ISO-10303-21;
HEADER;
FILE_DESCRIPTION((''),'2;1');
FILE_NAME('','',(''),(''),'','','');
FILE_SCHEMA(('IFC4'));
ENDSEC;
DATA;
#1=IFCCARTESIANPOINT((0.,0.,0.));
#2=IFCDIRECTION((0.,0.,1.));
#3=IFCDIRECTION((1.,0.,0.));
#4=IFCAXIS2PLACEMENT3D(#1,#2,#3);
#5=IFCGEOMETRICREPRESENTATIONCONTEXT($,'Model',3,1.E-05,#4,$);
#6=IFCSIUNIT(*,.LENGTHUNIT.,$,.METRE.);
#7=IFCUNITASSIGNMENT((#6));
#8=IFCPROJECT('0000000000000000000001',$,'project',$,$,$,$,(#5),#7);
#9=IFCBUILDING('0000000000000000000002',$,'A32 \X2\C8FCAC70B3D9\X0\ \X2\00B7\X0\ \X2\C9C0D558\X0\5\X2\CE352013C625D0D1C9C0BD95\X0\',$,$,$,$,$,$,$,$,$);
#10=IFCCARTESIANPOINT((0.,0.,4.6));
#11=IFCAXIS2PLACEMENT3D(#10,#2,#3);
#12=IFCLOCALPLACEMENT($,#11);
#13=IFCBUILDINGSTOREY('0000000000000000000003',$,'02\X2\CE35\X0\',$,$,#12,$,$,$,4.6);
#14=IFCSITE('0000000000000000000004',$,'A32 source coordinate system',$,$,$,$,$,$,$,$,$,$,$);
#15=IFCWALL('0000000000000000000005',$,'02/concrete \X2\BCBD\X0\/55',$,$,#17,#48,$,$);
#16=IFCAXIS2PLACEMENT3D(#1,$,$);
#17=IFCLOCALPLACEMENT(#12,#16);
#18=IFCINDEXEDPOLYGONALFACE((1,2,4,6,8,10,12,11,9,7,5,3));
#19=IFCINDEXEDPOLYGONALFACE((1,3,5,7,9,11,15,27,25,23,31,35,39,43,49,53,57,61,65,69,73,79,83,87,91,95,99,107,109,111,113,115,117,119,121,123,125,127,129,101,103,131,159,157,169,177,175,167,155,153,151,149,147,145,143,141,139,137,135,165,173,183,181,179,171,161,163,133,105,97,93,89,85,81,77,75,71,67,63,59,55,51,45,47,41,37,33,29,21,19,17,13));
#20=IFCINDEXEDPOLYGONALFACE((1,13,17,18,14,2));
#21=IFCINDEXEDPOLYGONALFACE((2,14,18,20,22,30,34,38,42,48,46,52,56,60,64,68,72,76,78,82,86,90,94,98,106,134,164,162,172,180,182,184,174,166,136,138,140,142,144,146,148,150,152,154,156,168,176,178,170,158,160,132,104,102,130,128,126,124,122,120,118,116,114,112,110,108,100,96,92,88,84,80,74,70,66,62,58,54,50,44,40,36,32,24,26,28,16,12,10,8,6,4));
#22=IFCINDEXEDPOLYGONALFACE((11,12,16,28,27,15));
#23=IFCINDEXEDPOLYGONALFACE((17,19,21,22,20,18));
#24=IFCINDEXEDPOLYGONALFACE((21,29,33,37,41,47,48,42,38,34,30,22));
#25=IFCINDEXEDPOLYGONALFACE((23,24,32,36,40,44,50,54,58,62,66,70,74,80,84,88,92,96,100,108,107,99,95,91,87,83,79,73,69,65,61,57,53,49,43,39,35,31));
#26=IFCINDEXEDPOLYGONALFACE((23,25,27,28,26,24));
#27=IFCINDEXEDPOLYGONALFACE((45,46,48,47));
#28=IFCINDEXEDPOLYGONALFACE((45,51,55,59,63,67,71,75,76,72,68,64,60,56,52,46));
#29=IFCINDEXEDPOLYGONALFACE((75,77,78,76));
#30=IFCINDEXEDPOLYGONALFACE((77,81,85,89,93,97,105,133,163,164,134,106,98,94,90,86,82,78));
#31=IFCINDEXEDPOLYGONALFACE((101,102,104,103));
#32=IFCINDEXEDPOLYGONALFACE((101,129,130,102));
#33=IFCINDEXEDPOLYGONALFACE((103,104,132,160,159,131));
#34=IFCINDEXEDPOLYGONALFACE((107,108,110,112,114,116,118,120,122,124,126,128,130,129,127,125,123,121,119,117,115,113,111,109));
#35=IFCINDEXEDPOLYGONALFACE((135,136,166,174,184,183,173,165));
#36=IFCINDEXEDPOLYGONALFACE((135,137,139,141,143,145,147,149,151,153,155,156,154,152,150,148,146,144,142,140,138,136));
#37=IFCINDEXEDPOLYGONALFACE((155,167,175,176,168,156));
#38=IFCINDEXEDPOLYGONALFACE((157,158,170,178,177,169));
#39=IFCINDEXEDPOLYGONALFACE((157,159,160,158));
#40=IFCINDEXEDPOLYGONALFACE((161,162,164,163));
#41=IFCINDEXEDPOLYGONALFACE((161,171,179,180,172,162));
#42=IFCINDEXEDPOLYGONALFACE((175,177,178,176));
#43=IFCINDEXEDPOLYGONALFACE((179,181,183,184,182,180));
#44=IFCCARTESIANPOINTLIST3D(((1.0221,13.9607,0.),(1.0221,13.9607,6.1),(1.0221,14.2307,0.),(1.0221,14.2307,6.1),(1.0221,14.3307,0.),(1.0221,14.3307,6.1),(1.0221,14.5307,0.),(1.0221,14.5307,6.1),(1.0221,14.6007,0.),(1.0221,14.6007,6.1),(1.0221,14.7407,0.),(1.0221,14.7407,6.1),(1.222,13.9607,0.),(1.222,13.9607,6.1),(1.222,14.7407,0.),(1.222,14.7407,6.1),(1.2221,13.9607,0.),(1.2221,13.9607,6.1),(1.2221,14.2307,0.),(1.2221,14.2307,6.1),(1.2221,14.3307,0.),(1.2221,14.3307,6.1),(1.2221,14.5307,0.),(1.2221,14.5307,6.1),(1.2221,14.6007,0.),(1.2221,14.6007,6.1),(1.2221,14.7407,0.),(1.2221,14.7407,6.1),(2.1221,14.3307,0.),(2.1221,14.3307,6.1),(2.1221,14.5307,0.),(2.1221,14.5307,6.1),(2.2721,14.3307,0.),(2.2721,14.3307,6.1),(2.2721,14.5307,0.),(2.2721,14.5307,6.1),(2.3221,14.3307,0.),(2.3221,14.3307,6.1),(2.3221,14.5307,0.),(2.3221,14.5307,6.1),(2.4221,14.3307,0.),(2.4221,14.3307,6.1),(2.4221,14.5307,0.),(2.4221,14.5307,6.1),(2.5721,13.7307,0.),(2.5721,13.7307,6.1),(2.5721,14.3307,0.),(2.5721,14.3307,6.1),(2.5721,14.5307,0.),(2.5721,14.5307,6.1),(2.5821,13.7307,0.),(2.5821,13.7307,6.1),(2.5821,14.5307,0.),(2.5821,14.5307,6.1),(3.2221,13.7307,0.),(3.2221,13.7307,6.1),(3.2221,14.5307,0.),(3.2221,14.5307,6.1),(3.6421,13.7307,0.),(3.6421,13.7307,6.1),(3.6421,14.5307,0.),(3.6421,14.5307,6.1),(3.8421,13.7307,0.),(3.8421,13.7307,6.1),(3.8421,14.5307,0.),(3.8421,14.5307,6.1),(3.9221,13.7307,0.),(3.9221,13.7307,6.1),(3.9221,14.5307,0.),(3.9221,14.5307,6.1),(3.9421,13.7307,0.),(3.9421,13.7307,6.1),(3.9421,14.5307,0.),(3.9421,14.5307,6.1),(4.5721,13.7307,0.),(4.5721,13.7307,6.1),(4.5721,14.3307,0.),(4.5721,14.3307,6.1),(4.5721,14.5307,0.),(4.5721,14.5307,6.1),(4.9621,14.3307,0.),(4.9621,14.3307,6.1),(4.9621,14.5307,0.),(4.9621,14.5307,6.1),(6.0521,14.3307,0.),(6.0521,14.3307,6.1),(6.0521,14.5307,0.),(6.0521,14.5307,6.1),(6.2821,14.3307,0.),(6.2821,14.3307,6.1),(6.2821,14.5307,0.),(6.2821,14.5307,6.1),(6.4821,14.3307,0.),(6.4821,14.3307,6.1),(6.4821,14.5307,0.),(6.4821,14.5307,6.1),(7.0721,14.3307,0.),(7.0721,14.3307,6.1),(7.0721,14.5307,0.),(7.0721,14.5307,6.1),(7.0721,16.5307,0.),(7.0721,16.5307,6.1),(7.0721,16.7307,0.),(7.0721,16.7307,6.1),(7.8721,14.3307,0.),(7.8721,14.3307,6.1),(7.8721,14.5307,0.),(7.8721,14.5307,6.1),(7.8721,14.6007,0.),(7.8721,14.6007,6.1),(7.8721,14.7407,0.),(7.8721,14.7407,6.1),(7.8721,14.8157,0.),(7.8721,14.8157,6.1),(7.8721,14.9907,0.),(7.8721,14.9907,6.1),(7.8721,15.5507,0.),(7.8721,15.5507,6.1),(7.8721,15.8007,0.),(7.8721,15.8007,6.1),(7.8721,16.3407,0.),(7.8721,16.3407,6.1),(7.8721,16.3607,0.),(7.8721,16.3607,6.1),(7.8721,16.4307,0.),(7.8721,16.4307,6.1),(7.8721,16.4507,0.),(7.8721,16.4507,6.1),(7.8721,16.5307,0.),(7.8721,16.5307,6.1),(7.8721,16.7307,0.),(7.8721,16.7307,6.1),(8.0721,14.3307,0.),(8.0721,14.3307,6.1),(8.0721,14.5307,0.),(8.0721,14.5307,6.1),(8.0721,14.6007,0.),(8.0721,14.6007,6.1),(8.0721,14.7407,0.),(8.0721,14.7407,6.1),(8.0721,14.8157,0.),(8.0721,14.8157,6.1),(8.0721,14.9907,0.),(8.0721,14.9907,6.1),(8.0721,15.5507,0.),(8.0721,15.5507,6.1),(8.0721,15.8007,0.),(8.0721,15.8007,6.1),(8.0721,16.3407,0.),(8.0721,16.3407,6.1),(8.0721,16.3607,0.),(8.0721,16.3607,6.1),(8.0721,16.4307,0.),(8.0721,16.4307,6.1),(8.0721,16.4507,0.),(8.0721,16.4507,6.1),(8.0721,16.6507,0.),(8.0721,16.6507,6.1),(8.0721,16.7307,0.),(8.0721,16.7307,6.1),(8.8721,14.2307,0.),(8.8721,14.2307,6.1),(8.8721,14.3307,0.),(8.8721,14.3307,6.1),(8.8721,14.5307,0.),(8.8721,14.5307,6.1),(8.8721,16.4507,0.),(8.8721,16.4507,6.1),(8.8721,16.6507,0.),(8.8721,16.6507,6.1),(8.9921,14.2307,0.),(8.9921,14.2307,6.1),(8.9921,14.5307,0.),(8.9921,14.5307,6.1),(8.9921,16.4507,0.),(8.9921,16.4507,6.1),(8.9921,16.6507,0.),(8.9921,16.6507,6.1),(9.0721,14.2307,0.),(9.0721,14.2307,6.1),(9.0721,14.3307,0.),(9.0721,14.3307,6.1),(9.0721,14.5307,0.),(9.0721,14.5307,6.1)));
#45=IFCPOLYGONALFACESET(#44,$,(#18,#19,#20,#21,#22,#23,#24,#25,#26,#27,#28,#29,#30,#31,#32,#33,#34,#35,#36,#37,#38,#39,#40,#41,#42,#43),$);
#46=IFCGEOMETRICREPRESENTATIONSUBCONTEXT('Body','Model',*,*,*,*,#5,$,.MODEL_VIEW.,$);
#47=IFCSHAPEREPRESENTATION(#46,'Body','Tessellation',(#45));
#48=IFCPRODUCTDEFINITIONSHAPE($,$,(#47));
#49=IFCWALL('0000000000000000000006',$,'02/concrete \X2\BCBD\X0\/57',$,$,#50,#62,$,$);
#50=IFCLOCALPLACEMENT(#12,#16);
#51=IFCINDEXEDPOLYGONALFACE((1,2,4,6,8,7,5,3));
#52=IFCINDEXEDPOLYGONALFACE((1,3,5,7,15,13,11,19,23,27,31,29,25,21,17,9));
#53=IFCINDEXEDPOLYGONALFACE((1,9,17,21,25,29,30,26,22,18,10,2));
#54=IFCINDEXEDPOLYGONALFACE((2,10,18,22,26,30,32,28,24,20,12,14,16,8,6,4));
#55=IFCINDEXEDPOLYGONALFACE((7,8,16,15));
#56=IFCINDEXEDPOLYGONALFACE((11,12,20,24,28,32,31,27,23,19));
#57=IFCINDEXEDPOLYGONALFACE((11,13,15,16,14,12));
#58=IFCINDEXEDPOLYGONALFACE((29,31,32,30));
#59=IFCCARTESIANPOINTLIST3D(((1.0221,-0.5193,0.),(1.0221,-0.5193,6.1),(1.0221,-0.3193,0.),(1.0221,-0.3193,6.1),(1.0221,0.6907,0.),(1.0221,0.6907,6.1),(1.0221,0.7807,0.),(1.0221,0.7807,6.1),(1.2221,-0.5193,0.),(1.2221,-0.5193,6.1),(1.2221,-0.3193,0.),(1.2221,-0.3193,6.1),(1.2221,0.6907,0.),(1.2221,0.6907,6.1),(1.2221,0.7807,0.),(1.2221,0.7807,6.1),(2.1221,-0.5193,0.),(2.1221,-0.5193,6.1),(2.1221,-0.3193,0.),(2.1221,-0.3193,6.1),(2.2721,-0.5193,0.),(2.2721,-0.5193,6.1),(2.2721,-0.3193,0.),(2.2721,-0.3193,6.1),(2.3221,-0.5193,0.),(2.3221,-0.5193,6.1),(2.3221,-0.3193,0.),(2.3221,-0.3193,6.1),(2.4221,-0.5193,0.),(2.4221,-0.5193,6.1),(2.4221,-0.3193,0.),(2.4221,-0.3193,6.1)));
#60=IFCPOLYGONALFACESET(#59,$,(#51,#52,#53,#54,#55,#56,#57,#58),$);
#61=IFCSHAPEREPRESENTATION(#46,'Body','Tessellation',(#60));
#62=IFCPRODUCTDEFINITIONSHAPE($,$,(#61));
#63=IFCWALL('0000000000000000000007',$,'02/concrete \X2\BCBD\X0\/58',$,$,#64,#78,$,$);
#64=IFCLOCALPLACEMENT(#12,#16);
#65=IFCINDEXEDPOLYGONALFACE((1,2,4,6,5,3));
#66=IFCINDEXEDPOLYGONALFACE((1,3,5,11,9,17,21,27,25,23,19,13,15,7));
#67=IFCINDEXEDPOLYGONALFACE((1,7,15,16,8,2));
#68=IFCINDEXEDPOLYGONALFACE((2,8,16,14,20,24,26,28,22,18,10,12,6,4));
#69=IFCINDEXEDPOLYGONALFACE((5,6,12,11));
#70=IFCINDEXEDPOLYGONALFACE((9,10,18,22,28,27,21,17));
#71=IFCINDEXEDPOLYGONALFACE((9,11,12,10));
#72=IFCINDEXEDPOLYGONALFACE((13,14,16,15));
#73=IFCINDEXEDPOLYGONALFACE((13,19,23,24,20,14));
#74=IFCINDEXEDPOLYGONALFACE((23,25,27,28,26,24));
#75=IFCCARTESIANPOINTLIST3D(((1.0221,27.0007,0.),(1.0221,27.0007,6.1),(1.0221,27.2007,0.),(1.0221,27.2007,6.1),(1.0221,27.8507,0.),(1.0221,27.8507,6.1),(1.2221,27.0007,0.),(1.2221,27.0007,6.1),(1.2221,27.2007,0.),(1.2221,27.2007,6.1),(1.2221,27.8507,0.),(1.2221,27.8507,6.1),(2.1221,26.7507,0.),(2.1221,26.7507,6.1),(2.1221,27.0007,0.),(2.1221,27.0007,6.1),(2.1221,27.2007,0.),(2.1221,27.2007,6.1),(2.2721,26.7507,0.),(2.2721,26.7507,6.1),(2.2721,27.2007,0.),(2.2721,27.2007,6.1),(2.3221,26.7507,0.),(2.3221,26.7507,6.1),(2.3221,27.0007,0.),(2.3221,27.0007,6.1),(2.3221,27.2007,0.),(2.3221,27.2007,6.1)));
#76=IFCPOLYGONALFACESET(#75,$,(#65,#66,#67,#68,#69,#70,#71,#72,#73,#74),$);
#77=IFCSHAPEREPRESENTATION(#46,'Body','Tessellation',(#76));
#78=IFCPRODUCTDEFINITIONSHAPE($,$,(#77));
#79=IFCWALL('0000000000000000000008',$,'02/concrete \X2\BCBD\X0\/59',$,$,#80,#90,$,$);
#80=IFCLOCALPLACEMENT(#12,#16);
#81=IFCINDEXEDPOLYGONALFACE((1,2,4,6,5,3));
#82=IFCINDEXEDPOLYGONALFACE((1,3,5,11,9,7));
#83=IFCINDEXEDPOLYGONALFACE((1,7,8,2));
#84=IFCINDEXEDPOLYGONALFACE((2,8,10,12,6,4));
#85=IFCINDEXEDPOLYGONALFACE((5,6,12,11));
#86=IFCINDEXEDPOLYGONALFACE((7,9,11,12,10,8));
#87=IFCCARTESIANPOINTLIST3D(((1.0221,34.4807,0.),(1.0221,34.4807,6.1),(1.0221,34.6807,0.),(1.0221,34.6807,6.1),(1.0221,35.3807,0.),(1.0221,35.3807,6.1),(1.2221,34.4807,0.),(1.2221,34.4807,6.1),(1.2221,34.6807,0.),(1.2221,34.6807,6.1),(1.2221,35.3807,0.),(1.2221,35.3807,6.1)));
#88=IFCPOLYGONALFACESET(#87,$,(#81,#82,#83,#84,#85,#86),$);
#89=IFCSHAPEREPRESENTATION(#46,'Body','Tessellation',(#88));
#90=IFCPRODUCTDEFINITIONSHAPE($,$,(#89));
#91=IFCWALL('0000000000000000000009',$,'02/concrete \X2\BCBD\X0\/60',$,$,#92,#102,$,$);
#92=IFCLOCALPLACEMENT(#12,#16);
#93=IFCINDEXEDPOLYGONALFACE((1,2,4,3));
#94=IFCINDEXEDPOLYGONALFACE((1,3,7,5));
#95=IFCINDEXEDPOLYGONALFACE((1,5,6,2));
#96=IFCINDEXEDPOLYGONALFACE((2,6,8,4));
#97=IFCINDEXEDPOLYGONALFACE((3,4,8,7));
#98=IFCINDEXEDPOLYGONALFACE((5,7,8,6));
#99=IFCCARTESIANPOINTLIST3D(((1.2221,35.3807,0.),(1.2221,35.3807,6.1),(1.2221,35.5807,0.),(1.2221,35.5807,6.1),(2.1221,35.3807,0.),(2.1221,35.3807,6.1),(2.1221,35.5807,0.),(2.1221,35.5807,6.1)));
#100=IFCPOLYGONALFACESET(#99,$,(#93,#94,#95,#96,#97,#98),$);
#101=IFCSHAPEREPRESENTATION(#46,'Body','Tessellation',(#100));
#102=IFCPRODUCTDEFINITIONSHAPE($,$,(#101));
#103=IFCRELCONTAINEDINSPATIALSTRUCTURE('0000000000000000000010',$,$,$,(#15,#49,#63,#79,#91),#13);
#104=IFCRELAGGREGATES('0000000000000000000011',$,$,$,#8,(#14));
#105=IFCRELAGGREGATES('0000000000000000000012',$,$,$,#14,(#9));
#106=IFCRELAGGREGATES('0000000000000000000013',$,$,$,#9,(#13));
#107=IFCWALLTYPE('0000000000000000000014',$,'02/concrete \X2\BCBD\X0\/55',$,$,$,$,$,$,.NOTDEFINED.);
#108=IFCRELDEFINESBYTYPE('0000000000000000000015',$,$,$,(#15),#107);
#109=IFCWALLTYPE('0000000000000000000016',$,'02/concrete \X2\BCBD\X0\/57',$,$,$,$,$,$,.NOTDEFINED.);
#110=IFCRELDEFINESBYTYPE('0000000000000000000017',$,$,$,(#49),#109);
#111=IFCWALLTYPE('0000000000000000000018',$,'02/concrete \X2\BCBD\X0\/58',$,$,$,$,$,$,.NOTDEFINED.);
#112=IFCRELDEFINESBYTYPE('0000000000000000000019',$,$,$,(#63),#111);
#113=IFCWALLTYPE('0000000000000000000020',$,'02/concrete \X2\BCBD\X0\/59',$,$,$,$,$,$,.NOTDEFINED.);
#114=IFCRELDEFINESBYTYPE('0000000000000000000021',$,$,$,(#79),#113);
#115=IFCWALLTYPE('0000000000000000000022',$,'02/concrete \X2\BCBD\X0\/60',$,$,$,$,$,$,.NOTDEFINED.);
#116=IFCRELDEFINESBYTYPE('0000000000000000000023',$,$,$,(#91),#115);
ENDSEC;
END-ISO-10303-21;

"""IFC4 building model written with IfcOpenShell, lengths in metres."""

from ifc_helpers import new_model, si_unit, frame, origin, origin_with_axes, place, context, subcontext, project, spatial, polyline, outline, extrude, source, transform, mapped, type_object, type_shapes, element, save


model = new_model("IFC4")

# Units and contexts
model_context = context("Model", 3, precision=1e-05, world=origin_with_axes())
body_context = subcontext(model_context, "Body", "Model", "MODEL_VIEW")
ifc_project = project(units=[si_unit("LENGTHUNIT", "METRE")], contexts=[model_context])

# Site, building, storey
site = spatial("IfcSite", under=ifc_project, Name="A32 source coordinate system")
building = spatial("IfcBuilding", under=site, Name="A32 주거동 · 지하5층–옥탑지붕")
storey_placement = place(None, frame((0.0, 0.0, 4.6), z_axis=(0.0, 0.0, 1.0), x_axis=(1.0, 0.0, 0.0)))
storey = spatial("IfcBuildingStorey", under=building, at=storey_placement, Name="02층", Elevation=4.6)

# Walls
wall_type_1 = type_object("IfcWallType", Name="02/concrete 벽/55", PredefinedType="NOTDEFINED")
shared_shape_1 = source(origin(), body_context, "Body", "SweptSolid", [
    extrude(outline(polyline([(2.1221, 14.5307), (2.2721, 14.5307), (2.3221, 14.5307), (2.4221, 14.5307), (2.5721, 14.5307), (2.5821, 14.5307), (3.2221, 14.5307), (3.6421, 14.5307), (3.8421, 14.5307), (3.9221, 14.5307), (3.9421, 14.5307), (4.5721, 14.5307), (4.9621, 14.5307), (6.0521, 14.5307), (6.2821, 14.5307), (6.4821, 14.5307), (7.0721, 14.5307), (7.8721, 14.5307), (7.8721, 14.6007), (7.8721, 14.7407), (7.8721, 14.8157), (7.8721, 14.9907), (7.8721, 15.5507), (7.8721, 15.8007), (7.8721, 16.3407), (7.8721, 16.3607), (7.8721, 16.4307), (7.8721, 16.4507), (7.8721, 16.5307), (7.0721, 16.5307), (7.0721, 16.7307), (7.8721, 16.7307), (8.0721, 16.7307), (8.0721, 16.6507), (8.8721, 16.6507), (8.9921, 16.6507), (8.9921, 16.4507), (8.8721, 16.4507), (8.0721, 16.4507), (8.0721, 16.4307), (8.0721, 16.3607), (8.0721, 16.3407), (8.0721, 15.8007), (8.0721, 15.5507), (8.0721, 14.9907), (8.0721, 14.8157), (8.0721, 14.7407), (8.0721, 14.6007), (8.0721, 14.5307), (8.8721, 14.5307), (8.9921, 14.5307), (9.0721, 14.5307), (9.0721, 14.3307), (9.0721, 14.2307), (8.9921, 14.2307), (8.8721, 14.2307), (8.8721, 14.3307), (8.0721, 14.3307), (7.8721, 14.3307), (7.0721, 14.3307), (6.4821, 14.3307), (6.2821, 14.3307), (6.0521, 14.3307), (4.9621, 14.3307), (4.5721, 14.3307), (4.5721, 13.7307), (3.9421, 13.7307), (3.9221, 13.7307), (3.8421, 13.7307), (3.6421, 13.7307), (3.2221, 13.7307), (2.5821, 13.7307), (2.5721, 13.7307), (2.5721, 14.3307), (2.4221, 14.3307), (2.3221, 14.3307), (2.2721, 14.3307), (2.1221, 14.3307), (1.2221, 14.3307), (1.2221, 14.2307), (1.2221, 13.9607), (1.222, 13.9607), (1.0221, 13.9607), (1.0221, 14.2307), (1.0221, 14.3307), (1.0221, 14.5307), (1.0221, 14.6007), (1.0221, 14.7407), (1.222, 14.7407), (1.2221, 14.7407), (1.2221, 14.6007), (1.2221, 14.5307), (2.1221, 14.5307)])), origin(), (0.0, 0.0, 1.0), 6.1),
])
type_shapes(wall_type_1, [shared_shape_1])
wall_1_placement = place(storey_placement, origin_with_axes())
element("IfcWall", 1, at=wall_1_placement, inside=storey, type_object=wall_type_1, Name="02/concrete 벽/55", context=body_context, shape_type="MappedRepresentation", body=[
    mapped(shared_shape_1, transform((0.0, 0.0, 0.0), scale=1.0)),
])
wall_type_2 = type_object("IfcWallType", Name="02/concrete 벽/57", PredefinedType="NOTDEFINED")
shared_shape_2 = source(origin(), body_context, "Body", "SweptSolid", [
    extrude(outline(polyline([(2.1221, -0.3193), (2.2721, -0.3193), (2.3221, -0.3193), (2.4221, -0.3193), (2.4221, -0.5193), (2.3221, -0.5193), (2.2721, -0.5193), (2.1221, -0.5193), (1.2221, -0.5193), (1.0221, -0.5193), (1.0221, -0.3193), (1.0221, 0.6907), (1.0221, 0.7807), (1.2221, 0.7807), (1.2221, 0.6907), (1.2221, -0.3193), (2.1221, -0.3193)])), origin(), (0.0, 0.0, 1.0), 6.1),
])
type_shapes(wall_type_2, [shared_shape_2])
wall_2_placement = place(storey_placement, origin_with_axes())
element("IfcWall", 2, at=wall_2_placement, inside=storey, type_object=wall_type_2, Name="02/concrete 벽/57", context=body_context, shape_type="MappedRepresentation", body=[
    mapped(shared_shape_2, transform((0.0, 0.0, 0.0), scale=1.0)),
])
wall_type_3 = type_object("IfcWallType", Name="02/concrete 벽/58", PredefinedType="NOTDEFINED")
shared_shape_3 = source(origin(), body_context, "Body", "SweptSolid", [
    extrude(outline(polyline([(1.2221, 27.2007), (2.1221, 27.2007), (2.2721, 27.2007), (2.3221, 27.2007), (2.3221, 27.0007), (2.3221, 26.7507), (2.2721, 26.7507), (2.1221, 26.7507), (2.1221, 27.0007), (1.2221, 27.0007), (1.0221, 27.0007), (1.0221, 27.2007), (1.0221, 27.8507), (1.2221, 27.8507), (1.2221, 27.2007)])), origin(), (0.0, 0.0, 1.0), 6.1),
])
type_shapes(wall_type_3, [shared_shape_3])
wall_3_placement = place(storey_placement, origin_with_axes())
element("IfcWall", 3, at=wall_3_placement, inside=storey, type_object=wall_type_3, Name="02/concrete 벽/58", context=body_context, shape_type="MappedRepresentation", body=[
    mapped(shared_shape_3, transform((0.0, 0.0, 0.0), scale=1.0)),
])
wall_type_4 = type_object("IfcWallType", Name="02/concrete 벽/59", PredefinedType="NOTDEFINED")
shared_shape_4 = source(origin(), body_context, "Body", "SweptSolid", [
    extrude(outline(polyline([(1.0221, 35.3807), (1.2221, 35.3807), (1.2221, 34.6807), (1.2221, 34.4807), (1.0221, 34.4807), (1.0221, 34.6807), (1.0221, 35.3807)])), origin(), (0.0, 0.0, 1.0), 6.1),
])
type_shapes(wall_type_4, [shared_shape_4])
wall_4_placement = place(storey_placement, origin_with_axes())
element("IfcWall", 4, at=wall_4_placement, inside=storey, type_object=wall_type_4, Name="02/concrete 벽/59", context=body_context, shape_type="MappedRepresentation", body=[
    mapped(shared_shape_4, transform((0.0, 0.0, 0.0), scale=1.0)),
])
wall_type_5 = type_object("IfcWallType", Name="02/concrete 벽/60", PredefinedType="NOTDEFINED")
shared_shape_5 = source(origin(), body_context, "Body", "SweptSolid", [
    extrude(outline(polyline([(2.1221, 35.3807), (1.2221, 35.3807), (1.2221, 35.5807), (2.1221, 35.5807), (2.1221, 35.3807)])), origin(), (0.0, 0.0, 1.0), 6.1),
])
type_shapes(wall_type_5, [shared_shape_5])
wall_5_placement = place(storey_placement, origin_with_axes())
element("IfcWall", 5, at=wall_5_placement, inside=storey, type_object=wall_type_5, Name="02/concrete 벽/60", context=body_context, shape_type="MappedRepresentation", body=[
    mapped(shared_shape_5, transform((0.0, 0.0, 0.0), scale=1.0)),
])

save(model, "model.ifc")
